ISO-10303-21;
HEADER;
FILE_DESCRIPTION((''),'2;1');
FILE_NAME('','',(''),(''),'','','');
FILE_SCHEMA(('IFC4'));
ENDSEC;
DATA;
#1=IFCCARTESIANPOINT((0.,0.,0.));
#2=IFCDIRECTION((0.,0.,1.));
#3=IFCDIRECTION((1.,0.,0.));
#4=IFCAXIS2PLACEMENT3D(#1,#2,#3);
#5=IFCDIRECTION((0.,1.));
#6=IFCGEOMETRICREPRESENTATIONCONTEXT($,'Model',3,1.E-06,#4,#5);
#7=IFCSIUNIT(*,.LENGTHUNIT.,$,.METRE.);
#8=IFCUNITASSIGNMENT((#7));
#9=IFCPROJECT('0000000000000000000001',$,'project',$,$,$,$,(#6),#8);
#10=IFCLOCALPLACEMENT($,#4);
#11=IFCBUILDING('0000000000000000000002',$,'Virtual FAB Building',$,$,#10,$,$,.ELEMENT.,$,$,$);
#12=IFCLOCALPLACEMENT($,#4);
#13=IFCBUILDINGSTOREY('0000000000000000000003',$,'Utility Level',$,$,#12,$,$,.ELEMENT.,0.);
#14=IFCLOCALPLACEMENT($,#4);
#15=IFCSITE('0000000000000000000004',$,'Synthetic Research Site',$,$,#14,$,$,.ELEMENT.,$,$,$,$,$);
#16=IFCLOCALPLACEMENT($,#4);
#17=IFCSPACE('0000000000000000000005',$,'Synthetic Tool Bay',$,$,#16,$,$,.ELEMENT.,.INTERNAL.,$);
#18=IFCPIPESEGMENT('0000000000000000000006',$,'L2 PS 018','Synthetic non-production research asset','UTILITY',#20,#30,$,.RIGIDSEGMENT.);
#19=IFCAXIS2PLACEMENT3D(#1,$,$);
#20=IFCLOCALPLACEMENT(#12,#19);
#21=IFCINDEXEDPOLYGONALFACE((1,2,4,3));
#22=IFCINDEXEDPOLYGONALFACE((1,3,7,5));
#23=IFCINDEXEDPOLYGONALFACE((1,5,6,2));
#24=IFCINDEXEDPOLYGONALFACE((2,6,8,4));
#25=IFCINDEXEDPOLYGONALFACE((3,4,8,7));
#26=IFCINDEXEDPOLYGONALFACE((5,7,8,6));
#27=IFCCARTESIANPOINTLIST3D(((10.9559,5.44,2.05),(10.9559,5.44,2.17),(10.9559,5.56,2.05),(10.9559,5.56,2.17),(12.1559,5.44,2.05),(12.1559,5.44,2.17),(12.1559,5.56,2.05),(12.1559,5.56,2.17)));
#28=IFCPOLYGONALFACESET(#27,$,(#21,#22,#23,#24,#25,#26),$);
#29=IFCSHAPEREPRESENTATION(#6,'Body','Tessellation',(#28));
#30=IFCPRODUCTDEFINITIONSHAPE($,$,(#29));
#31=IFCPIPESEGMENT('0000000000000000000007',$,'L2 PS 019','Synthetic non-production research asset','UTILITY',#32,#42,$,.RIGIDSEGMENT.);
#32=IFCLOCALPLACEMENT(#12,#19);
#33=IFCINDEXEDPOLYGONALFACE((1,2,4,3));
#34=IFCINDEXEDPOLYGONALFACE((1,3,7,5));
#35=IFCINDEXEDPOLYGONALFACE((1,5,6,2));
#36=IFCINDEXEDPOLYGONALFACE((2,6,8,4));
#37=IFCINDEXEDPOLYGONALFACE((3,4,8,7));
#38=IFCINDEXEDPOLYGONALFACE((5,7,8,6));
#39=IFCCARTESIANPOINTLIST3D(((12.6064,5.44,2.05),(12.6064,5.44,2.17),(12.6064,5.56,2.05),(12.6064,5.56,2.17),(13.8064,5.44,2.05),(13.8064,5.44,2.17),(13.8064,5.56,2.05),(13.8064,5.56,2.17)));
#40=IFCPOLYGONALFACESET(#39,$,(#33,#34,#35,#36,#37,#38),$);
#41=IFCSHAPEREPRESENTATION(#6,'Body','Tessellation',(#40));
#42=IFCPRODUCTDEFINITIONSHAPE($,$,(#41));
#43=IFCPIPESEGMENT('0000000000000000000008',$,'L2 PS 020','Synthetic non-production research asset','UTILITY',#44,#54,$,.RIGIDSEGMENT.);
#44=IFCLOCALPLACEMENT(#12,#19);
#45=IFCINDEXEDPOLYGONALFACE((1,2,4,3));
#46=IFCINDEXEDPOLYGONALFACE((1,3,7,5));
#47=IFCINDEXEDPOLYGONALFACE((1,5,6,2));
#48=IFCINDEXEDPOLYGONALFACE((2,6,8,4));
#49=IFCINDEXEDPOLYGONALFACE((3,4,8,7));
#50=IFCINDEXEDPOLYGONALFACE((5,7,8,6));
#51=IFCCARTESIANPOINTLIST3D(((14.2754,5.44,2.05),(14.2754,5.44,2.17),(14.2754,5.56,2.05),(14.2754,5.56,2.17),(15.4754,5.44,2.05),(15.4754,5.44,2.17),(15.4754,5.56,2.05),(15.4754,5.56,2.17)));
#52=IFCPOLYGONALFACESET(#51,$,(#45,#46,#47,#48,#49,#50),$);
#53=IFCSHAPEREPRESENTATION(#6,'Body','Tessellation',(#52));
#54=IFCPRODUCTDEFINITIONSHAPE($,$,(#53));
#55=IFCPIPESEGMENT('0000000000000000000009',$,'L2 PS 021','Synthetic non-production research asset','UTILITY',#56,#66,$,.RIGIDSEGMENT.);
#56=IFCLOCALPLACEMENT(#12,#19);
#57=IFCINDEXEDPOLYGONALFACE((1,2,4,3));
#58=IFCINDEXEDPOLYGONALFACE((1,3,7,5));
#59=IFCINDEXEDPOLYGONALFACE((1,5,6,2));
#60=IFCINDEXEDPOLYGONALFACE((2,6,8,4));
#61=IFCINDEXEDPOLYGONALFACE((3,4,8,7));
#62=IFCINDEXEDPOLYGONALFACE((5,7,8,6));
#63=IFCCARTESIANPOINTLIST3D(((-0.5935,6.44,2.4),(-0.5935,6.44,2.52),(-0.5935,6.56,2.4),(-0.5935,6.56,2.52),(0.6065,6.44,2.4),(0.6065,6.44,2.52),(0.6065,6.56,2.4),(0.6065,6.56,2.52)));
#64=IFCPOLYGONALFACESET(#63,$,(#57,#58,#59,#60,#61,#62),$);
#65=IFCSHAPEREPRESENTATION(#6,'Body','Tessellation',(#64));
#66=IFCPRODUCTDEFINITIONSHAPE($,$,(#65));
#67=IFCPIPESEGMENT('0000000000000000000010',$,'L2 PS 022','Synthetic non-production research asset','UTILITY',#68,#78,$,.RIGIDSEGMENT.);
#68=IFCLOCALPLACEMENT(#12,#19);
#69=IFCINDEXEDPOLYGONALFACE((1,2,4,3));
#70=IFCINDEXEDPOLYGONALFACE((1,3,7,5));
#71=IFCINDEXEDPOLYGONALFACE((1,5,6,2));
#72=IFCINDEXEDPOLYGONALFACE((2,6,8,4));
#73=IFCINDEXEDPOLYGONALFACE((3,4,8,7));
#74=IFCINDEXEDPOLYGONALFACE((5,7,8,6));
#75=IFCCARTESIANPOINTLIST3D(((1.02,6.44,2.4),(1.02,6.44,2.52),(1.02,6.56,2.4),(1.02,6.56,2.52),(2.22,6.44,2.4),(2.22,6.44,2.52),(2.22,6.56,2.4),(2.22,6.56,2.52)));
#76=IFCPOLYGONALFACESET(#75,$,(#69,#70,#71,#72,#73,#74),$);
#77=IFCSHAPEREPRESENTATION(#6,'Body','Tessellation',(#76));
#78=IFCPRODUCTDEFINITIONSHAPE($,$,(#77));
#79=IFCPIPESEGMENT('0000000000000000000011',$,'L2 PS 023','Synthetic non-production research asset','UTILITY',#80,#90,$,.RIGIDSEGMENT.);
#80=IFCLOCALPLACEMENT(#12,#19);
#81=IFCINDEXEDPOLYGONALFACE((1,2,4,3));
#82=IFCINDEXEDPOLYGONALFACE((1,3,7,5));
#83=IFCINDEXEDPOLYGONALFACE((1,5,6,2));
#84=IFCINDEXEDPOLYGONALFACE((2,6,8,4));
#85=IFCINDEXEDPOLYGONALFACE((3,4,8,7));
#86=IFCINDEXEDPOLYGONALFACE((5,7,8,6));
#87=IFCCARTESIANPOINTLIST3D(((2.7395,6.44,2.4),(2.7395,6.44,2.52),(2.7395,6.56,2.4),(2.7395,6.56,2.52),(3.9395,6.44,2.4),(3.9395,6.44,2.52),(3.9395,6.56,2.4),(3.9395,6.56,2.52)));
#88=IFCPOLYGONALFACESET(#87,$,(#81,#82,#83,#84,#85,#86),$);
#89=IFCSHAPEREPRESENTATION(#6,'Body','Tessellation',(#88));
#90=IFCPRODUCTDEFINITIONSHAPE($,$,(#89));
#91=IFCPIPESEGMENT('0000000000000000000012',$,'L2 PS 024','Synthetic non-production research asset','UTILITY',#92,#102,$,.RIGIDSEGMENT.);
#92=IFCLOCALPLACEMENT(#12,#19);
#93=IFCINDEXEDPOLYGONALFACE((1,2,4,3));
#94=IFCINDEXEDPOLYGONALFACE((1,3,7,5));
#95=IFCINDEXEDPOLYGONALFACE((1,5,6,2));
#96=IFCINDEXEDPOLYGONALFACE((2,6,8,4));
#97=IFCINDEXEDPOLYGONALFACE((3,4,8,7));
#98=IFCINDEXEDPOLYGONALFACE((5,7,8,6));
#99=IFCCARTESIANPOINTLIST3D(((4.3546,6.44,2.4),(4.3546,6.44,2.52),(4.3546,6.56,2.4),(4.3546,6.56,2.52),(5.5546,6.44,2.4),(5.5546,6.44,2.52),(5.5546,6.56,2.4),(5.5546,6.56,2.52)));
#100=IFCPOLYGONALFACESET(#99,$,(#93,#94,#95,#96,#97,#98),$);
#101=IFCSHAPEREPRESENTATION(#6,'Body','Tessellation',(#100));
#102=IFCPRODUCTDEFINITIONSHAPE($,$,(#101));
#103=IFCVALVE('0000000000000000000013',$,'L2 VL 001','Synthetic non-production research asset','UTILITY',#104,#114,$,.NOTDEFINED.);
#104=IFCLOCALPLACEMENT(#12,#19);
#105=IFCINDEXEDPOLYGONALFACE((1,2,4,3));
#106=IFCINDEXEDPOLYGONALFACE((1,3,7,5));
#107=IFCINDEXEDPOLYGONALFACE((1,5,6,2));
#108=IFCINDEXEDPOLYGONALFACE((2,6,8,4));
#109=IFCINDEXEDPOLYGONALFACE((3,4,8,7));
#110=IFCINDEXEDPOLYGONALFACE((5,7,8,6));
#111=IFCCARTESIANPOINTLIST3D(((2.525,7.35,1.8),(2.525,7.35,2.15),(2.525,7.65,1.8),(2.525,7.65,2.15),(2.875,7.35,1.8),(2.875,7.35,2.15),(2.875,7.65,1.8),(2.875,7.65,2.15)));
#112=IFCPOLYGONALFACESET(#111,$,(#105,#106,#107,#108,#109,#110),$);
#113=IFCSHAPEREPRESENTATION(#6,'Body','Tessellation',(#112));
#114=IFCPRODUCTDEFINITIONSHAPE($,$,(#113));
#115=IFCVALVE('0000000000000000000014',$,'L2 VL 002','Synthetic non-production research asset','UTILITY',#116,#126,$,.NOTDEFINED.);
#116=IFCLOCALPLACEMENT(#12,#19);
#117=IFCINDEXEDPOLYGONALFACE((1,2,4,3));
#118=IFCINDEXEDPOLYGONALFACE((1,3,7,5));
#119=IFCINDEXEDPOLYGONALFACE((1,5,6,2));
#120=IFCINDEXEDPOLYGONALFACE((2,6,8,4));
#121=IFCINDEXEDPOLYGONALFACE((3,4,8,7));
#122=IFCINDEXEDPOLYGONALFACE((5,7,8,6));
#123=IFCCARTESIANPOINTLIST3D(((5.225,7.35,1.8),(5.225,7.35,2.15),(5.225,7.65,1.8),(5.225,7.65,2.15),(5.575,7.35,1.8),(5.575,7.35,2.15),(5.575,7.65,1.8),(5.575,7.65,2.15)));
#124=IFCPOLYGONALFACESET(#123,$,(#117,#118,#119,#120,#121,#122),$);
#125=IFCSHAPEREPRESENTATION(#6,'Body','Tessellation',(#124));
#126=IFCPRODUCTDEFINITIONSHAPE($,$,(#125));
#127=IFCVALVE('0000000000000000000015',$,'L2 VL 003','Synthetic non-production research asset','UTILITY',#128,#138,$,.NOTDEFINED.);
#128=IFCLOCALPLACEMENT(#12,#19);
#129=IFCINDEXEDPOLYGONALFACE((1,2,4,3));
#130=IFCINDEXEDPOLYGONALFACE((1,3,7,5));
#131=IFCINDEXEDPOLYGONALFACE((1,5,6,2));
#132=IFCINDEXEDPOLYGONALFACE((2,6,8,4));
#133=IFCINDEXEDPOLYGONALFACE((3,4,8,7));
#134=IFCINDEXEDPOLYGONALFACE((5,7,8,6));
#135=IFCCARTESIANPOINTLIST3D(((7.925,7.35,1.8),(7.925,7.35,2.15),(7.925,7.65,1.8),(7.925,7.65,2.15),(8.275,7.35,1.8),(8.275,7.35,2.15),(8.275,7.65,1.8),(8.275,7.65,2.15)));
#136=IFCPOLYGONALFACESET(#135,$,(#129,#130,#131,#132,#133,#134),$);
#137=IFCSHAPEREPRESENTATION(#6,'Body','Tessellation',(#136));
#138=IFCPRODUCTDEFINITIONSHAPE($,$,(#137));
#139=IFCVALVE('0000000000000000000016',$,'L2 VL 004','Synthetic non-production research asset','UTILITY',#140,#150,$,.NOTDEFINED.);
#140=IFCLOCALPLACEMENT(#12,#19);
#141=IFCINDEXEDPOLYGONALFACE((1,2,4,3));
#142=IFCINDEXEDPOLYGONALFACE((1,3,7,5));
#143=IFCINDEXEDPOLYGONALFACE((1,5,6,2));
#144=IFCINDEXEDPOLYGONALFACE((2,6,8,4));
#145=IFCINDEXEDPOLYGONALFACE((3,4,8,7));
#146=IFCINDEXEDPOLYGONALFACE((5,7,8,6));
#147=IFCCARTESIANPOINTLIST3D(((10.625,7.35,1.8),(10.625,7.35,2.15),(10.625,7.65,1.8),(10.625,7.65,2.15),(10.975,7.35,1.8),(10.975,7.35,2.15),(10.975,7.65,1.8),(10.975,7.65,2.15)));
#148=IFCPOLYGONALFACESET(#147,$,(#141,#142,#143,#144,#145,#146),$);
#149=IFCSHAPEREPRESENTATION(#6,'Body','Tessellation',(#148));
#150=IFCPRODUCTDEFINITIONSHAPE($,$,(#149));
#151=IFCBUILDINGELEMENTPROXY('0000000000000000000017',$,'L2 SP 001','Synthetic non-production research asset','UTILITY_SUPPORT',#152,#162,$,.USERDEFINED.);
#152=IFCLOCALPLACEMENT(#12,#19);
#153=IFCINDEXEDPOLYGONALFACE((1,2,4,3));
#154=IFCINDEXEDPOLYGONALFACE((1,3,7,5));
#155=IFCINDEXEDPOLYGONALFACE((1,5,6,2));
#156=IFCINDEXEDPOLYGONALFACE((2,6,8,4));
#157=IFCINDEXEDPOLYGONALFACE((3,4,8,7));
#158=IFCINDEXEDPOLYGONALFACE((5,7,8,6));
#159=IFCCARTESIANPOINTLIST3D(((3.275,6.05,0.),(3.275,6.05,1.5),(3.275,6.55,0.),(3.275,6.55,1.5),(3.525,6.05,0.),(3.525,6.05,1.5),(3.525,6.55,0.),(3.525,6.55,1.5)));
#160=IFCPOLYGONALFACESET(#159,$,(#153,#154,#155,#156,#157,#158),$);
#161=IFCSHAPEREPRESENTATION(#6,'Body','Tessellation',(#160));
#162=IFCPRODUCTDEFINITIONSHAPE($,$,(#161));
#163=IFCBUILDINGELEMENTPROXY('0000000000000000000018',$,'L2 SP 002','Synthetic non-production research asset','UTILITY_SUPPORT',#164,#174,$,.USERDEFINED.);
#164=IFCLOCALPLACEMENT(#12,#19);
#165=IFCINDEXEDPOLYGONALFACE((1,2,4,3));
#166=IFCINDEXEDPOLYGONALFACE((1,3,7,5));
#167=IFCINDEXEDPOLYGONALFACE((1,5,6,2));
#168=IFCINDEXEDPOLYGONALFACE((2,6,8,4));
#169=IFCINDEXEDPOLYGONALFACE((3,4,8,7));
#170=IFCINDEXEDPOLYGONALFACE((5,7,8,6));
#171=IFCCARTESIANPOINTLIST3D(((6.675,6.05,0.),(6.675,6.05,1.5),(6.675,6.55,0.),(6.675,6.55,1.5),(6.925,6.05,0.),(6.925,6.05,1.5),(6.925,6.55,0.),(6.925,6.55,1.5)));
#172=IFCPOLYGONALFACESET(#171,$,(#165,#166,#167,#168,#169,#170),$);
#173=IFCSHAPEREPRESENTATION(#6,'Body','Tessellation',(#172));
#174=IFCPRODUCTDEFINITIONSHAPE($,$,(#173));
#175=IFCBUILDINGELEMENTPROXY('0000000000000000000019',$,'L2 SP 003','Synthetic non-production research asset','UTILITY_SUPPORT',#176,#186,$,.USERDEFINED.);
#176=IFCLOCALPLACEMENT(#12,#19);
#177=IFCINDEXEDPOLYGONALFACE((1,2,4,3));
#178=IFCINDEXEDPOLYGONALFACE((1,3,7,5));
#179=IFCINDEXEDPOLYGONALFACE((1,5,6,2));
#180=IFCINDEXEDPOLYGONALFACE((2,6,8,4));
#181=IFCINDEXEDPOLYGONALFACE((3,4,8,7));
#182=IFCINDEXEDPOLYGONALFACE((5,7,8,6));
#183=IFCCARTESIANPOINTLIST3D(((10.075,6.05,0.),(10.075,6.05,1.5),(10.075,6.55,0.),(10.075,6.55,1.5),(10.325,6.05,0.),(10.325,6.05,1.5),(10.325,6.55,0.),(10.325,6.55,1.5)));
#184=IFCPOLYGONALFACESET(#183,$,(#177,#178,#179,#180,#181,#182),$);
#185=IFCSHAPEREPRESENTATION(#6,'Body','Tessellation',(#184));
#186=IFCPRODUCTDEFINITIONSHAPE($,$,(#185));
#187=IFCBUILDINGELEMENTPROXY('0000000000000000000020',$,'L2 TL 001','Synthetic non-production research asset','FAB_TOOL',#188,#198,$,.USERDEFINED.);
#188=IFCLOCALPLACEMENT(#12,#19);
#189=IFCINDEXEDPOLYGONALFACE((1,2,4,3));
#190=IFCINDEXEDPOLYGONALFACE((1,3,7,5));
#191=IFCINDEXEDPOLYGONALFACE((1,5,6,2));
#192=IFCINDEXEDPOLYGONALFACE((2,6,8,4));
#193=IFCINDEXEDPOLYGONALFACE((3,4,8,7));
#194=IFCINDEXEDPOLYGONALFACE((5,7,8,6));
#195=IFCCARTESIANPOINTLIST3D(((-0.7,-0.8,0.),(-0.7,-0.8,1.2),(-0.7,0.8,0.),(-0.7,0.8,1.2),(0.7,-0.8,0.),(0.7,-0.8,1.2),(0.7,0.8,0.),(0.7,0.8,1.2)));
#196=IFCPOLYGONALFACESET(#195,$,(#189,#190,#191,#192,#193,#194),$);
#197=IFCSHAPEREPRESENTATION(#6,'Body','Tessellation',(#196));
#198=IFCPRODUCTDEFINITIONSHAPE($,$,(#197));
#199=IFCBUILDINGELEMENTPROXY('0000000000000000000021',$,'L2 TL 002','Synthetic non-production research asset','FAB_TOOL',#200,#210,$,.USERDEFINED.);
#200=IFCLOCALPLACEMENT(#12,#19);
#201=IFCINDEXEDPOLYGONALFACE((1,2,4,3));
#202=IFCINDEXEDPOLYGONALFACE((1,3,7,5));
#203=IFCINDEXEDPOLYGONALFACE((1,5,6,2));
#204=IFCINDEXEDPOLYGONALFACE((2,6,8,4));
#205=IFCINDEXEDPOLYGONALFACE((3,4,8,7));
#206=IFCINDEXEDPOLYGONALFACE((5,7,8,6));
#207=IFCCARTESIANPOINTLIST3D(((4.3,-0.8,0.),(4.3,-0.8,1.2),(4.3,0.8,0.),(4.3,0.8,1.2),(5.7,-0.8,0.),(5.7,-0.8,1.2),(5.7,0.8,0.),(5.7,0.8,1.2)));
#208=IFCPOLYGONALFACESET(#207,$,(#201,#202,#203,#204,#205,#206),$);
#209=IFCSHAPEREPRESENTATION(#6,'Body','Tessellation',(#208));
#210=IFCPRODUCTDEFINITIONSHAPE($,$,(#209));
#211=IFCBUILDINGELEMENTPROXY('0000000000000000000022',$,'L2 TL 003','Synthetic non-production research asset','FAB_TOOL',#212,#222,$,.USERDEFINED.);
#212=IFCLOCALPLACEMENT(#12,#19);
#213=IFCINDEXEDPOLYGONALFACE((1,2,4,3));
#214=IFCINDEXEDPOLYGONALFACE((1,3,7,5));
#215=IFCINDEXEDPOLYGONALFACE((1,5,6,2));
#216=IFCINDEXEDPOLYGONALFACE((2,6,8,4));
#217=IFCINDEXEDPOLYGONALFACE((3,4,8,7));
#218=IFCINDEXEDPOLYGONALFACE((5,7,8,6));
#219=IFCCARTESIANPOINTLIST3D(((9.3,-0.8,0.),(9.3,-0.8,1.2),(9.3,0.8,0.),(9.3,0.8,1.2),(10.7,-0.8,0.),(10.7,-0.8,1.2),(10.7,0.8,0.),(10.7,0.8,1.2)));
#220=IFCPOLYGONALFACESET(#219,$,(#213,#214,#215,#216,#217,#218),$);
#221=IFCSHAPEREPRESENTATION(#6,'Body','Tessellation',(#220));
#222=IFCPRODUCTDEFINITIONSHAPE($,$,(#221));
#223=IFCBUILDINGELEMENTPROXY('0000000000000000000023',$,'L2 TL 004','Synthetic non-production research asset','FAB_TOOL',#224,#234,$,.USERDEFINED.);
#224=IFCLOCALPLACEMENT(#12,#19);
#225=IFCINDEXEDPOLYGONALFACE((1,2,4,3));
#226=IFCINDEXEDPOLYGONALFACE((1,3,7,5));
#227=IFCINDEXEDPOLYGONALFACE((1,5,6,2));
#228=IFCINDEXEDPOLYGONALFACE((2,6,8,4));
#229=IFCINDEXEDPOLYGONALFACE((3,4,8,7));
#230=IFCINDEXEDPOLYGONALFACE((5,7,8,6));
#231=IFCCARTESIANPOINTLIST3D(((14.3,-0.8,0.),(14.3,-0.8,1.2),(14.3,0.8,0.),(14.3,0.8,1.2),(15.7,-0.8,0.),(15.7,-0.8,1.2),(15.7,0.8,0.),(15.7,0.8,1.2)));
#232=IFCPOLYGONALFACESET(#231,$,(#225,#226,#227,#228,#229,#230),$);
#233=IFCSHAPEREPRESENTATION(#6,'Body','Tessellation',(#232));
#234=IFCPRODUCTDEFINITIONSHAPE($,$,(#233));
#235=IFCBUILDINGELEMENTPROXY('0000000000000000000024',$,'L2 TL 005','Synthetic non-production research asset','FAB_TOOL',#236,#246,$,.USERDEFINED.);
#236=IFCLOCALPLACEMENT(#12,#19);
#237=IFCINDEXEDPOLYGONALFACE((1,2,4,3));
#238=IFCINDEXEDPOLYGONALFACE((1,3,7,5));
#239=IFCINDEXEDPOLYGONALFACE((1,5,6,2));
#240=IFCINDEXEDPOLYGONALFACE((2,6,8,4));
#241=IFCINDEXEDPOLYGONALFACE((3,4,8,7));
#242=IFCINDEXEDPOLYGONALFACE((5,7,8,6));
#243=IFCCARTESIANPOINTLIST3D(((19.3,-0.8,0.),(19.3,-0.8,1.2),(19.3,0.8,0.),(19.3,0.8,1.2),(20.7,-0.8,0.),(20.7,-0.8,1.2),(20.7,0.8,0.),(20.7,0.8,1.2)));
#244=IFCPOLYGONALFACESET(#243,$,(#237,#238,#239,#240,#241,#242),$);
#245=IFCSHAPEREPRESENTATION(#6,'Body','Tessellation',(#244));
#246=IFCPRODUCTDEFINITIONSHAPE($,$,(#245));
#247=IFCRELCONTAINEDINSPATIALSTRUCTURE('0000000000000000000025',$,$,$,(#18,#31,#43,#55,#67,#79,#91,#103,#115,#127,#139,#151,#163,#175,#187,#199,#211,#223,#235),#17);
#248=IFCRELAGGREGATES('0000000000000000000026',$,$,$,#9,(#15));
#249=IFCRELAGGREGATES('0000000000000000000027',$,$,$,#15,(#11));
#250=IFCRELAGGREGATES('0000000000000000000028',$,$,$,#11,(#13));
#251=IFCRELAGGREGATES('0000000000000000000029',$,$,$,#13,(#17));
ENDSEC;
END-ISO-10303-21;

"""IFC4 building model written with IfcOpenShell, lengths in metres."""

from ifc_helpers import new_model, si_unit, direction, frame, origin_with_axes, origin_2d_with_axis, place, context, project, spatial, rectangle, extrude, element, save


model = new_model("IFC4")

# Units and contexts
model_context = context("Model", 3, precision=1e-06, world=origin_with_axes(), true_north=direction((0.0, 1.0)))
ifc_project = project(units=[si_unit("LENGTHUNIT", "METRE")], contexts=[model_context])

# Site, building, storey, space
site_placement = place(None, origin_with_axes())
site = spatial("IfcSite", under=ifc_project, at=site_placement, Name="Synthetic Research Site", CompositionType="ELEMENT")
building_placement = place(None, origin_with_axes())
building = spatial("IfcBuilding", under=site, at=building_placement, Name="Virtual FAB Building", CompositionType="ELEMENT")
storey_placement = place(None, origin_with_axes())
storey = spatial("IfcBuildingStorey", under=building, at=storey_placement, Name="Utility Level", CompositionType="ELEMENT", Elevation=0.0)
space_placement = place(None, origin_with_axes())
space = spatial("IfcSpace", under=storey, at=space_placement, Name="Synthetic Tool Bay", CompositionType="ELEMENT", PredefinedType="INTERNAL")

# Pipe segments
for number, where, z_axis, x_axis, name in (
    (1, (11.5559, 5.5, 2.05), (0.0, 0.0, 1.0), (1.0, 0.0, 0.0), "L2 PS 018"),
    (2, (13.2064, 5.5, 2.05), (0.0, 0.0, 1.0), (1.0, 0.0, 0.0), "L2 PS 019"),
    (3, (14.8754, 5.5, 2.05), (0.0, 0.0, 1.0), (1.0, 0.0, 0.0), "L2 PS 020"),
    (4, (0.0065, 6.5, 2.4), (0.0, 0.0, 1.0), (1.0, 0.0, 0.0), "L2 PS 021"),
    (5, (1.62, 6.5, 2.4), (0.0, 0.0, 1.0), (1.0, 0.0, 0.0), "L2 PS 022"),
    (6, (3.3395, 6.5, 2.4), (0.0, 0.0, 1.0), (1.0, 0.0, 0.0), "L2 PS 023"),
    (7, (4.9546, 6.5, 2.4), (0.0, 0.0, 1.0), (1.0, 0.0, 0.0), "L2 PS 024"),
):
    element("IfcPipeSegment", number, at=place(None, frame(where, z_axis=z_axis, x_axis=x_axis)), inside=space, Name=name, Description="Synthetic non-production research asset", ObjectType="UTILITY", PredefinedType="RIGIDSEGMENT", context=model_context, shape_type="SweptSolid", body=[
        extrude(rectangle(XDim=1.2, YDim=0.12, at=origin_2d_with_axis()), origin_with_axes(), (0.0, 0.0, 1.0), 0.12),
    ])

# Valves
for number, where, z_axis, x_axis, name in (
    (8, (2.7, 7.5, 1.8), (0.0, 0.0, 1.0), (1.0, 0.0, 0.0), "L2 VL 001"),
    (9, (5.4, 7.5, 1.8), (0.0, 0.0, 1.0), (1.0, 0.0, 0.0), "L2 VL 002"),
    (10, (8.1, 7.5, 1.8), (0.0, 0.0, 1.0), (1.0, 0.0, 0.0), "L2 VL 003"),
    (11, (10.8, 7.5, 1.8), (0.0, 0.0, 1.0), (1.0, 0.0, 0.0), "L2 VL 004"),
):
    element("IfcValve", number, at=place(None, frame(where, z_axis=z_axis, x_axis=x_axis)), inside=space, Name=name, Description="Synthetic non-production research asset", ObjectType="UTILITY", PredefinedType="NOTDEFINED", context=model_context, shape_type="SweptSolid", body=[
        extrude(rectangle(XDim=0.35, YDim=0.3, at=origin_2d_with_axis()), origin_with_axes(), (0.0, 0.0, 1.0), 0.35),
    ])

# Building element proxies
for number, where, z_axis, x_axis, name in (
    (12, (3.4, 6.3, 0.0), (0.0, 0.0, 1.0), (1.0, 0.0, 0.0), "L2 SP 001"),
    (13, (6.8, 6.3, 0.0), (0.0, 0.0, 1.0), (1.0, 0.0, 0.0), "L2 SP 002"),
    (14, (10.2, 6.3, 0.0), (0.0, 0.0, 1.0), (1.0, 0.0, 0.0), "L2 SP 003"),
):
    element("IfcBuildingElementProxy", number, at=place(None, frame(where, z_axis=z_axis, x_axis=x_axis)), inside=space, Name=name, Description="Synthetic non-production research asset", ObjectType="UTILITY_SUPPORT", PredefinedType="USERDEFINED", context=model_context, shape_type="SweptSolid", body=[
        extrude(rectangle(XDim=0.25, YDim=0.5, at=origin_2d_with_axis()), origin_with_axes(), (0.0, 0.0, 1.0), 1.5),
    ])
for number, where, z_axis, x_axis, name in (
    (15, (0.0, 0.0, 0.0), (0.0, 0.0, 1.0), (1.0, 0.0, 0.0), "L2 TL 001"),
    (16, (5.0, 0.0, 0.0), (0.0, 0.0, 1.0), (1.0, 0.0, 0.0), "L2 TL 002"),
    (17, (10.0, 0.0, 0.0), (0.0, 0.0, 1.0), (1.0, 0.0, 0.0), "L2 TL 003"),
    (18, (15.0, 0.0, 0.0), (0.0, 0.0, 1.0), (1.0, 0.0, 0.0), "L2 TL 004"),
    (19, (20.0, 0.0, 0.0), (0.0, 0.0, 1.0), (1.0, 0.0, 0.0), "L2 TL 005"),
):
    element("IfcBuildingElementProxy", number, at=place(None, frame(where, z_axis=z_axis, x_axis=x_axis)), inside=space, Name=name, Description="Synthetic non-production research asset", ObjectType="FAB_TOOL", PredefinedType="USERDEFINED", context=model_context, shape_type="SweptSolid", body=[
        extrude(rectangle(XDim=1.4, YDim=1.6, at=origin_2d_with_axis()), origin_with_axes(), (0.0, 0.0, 1.0), 1.2),
    ])

save(model, "model.ifc")
